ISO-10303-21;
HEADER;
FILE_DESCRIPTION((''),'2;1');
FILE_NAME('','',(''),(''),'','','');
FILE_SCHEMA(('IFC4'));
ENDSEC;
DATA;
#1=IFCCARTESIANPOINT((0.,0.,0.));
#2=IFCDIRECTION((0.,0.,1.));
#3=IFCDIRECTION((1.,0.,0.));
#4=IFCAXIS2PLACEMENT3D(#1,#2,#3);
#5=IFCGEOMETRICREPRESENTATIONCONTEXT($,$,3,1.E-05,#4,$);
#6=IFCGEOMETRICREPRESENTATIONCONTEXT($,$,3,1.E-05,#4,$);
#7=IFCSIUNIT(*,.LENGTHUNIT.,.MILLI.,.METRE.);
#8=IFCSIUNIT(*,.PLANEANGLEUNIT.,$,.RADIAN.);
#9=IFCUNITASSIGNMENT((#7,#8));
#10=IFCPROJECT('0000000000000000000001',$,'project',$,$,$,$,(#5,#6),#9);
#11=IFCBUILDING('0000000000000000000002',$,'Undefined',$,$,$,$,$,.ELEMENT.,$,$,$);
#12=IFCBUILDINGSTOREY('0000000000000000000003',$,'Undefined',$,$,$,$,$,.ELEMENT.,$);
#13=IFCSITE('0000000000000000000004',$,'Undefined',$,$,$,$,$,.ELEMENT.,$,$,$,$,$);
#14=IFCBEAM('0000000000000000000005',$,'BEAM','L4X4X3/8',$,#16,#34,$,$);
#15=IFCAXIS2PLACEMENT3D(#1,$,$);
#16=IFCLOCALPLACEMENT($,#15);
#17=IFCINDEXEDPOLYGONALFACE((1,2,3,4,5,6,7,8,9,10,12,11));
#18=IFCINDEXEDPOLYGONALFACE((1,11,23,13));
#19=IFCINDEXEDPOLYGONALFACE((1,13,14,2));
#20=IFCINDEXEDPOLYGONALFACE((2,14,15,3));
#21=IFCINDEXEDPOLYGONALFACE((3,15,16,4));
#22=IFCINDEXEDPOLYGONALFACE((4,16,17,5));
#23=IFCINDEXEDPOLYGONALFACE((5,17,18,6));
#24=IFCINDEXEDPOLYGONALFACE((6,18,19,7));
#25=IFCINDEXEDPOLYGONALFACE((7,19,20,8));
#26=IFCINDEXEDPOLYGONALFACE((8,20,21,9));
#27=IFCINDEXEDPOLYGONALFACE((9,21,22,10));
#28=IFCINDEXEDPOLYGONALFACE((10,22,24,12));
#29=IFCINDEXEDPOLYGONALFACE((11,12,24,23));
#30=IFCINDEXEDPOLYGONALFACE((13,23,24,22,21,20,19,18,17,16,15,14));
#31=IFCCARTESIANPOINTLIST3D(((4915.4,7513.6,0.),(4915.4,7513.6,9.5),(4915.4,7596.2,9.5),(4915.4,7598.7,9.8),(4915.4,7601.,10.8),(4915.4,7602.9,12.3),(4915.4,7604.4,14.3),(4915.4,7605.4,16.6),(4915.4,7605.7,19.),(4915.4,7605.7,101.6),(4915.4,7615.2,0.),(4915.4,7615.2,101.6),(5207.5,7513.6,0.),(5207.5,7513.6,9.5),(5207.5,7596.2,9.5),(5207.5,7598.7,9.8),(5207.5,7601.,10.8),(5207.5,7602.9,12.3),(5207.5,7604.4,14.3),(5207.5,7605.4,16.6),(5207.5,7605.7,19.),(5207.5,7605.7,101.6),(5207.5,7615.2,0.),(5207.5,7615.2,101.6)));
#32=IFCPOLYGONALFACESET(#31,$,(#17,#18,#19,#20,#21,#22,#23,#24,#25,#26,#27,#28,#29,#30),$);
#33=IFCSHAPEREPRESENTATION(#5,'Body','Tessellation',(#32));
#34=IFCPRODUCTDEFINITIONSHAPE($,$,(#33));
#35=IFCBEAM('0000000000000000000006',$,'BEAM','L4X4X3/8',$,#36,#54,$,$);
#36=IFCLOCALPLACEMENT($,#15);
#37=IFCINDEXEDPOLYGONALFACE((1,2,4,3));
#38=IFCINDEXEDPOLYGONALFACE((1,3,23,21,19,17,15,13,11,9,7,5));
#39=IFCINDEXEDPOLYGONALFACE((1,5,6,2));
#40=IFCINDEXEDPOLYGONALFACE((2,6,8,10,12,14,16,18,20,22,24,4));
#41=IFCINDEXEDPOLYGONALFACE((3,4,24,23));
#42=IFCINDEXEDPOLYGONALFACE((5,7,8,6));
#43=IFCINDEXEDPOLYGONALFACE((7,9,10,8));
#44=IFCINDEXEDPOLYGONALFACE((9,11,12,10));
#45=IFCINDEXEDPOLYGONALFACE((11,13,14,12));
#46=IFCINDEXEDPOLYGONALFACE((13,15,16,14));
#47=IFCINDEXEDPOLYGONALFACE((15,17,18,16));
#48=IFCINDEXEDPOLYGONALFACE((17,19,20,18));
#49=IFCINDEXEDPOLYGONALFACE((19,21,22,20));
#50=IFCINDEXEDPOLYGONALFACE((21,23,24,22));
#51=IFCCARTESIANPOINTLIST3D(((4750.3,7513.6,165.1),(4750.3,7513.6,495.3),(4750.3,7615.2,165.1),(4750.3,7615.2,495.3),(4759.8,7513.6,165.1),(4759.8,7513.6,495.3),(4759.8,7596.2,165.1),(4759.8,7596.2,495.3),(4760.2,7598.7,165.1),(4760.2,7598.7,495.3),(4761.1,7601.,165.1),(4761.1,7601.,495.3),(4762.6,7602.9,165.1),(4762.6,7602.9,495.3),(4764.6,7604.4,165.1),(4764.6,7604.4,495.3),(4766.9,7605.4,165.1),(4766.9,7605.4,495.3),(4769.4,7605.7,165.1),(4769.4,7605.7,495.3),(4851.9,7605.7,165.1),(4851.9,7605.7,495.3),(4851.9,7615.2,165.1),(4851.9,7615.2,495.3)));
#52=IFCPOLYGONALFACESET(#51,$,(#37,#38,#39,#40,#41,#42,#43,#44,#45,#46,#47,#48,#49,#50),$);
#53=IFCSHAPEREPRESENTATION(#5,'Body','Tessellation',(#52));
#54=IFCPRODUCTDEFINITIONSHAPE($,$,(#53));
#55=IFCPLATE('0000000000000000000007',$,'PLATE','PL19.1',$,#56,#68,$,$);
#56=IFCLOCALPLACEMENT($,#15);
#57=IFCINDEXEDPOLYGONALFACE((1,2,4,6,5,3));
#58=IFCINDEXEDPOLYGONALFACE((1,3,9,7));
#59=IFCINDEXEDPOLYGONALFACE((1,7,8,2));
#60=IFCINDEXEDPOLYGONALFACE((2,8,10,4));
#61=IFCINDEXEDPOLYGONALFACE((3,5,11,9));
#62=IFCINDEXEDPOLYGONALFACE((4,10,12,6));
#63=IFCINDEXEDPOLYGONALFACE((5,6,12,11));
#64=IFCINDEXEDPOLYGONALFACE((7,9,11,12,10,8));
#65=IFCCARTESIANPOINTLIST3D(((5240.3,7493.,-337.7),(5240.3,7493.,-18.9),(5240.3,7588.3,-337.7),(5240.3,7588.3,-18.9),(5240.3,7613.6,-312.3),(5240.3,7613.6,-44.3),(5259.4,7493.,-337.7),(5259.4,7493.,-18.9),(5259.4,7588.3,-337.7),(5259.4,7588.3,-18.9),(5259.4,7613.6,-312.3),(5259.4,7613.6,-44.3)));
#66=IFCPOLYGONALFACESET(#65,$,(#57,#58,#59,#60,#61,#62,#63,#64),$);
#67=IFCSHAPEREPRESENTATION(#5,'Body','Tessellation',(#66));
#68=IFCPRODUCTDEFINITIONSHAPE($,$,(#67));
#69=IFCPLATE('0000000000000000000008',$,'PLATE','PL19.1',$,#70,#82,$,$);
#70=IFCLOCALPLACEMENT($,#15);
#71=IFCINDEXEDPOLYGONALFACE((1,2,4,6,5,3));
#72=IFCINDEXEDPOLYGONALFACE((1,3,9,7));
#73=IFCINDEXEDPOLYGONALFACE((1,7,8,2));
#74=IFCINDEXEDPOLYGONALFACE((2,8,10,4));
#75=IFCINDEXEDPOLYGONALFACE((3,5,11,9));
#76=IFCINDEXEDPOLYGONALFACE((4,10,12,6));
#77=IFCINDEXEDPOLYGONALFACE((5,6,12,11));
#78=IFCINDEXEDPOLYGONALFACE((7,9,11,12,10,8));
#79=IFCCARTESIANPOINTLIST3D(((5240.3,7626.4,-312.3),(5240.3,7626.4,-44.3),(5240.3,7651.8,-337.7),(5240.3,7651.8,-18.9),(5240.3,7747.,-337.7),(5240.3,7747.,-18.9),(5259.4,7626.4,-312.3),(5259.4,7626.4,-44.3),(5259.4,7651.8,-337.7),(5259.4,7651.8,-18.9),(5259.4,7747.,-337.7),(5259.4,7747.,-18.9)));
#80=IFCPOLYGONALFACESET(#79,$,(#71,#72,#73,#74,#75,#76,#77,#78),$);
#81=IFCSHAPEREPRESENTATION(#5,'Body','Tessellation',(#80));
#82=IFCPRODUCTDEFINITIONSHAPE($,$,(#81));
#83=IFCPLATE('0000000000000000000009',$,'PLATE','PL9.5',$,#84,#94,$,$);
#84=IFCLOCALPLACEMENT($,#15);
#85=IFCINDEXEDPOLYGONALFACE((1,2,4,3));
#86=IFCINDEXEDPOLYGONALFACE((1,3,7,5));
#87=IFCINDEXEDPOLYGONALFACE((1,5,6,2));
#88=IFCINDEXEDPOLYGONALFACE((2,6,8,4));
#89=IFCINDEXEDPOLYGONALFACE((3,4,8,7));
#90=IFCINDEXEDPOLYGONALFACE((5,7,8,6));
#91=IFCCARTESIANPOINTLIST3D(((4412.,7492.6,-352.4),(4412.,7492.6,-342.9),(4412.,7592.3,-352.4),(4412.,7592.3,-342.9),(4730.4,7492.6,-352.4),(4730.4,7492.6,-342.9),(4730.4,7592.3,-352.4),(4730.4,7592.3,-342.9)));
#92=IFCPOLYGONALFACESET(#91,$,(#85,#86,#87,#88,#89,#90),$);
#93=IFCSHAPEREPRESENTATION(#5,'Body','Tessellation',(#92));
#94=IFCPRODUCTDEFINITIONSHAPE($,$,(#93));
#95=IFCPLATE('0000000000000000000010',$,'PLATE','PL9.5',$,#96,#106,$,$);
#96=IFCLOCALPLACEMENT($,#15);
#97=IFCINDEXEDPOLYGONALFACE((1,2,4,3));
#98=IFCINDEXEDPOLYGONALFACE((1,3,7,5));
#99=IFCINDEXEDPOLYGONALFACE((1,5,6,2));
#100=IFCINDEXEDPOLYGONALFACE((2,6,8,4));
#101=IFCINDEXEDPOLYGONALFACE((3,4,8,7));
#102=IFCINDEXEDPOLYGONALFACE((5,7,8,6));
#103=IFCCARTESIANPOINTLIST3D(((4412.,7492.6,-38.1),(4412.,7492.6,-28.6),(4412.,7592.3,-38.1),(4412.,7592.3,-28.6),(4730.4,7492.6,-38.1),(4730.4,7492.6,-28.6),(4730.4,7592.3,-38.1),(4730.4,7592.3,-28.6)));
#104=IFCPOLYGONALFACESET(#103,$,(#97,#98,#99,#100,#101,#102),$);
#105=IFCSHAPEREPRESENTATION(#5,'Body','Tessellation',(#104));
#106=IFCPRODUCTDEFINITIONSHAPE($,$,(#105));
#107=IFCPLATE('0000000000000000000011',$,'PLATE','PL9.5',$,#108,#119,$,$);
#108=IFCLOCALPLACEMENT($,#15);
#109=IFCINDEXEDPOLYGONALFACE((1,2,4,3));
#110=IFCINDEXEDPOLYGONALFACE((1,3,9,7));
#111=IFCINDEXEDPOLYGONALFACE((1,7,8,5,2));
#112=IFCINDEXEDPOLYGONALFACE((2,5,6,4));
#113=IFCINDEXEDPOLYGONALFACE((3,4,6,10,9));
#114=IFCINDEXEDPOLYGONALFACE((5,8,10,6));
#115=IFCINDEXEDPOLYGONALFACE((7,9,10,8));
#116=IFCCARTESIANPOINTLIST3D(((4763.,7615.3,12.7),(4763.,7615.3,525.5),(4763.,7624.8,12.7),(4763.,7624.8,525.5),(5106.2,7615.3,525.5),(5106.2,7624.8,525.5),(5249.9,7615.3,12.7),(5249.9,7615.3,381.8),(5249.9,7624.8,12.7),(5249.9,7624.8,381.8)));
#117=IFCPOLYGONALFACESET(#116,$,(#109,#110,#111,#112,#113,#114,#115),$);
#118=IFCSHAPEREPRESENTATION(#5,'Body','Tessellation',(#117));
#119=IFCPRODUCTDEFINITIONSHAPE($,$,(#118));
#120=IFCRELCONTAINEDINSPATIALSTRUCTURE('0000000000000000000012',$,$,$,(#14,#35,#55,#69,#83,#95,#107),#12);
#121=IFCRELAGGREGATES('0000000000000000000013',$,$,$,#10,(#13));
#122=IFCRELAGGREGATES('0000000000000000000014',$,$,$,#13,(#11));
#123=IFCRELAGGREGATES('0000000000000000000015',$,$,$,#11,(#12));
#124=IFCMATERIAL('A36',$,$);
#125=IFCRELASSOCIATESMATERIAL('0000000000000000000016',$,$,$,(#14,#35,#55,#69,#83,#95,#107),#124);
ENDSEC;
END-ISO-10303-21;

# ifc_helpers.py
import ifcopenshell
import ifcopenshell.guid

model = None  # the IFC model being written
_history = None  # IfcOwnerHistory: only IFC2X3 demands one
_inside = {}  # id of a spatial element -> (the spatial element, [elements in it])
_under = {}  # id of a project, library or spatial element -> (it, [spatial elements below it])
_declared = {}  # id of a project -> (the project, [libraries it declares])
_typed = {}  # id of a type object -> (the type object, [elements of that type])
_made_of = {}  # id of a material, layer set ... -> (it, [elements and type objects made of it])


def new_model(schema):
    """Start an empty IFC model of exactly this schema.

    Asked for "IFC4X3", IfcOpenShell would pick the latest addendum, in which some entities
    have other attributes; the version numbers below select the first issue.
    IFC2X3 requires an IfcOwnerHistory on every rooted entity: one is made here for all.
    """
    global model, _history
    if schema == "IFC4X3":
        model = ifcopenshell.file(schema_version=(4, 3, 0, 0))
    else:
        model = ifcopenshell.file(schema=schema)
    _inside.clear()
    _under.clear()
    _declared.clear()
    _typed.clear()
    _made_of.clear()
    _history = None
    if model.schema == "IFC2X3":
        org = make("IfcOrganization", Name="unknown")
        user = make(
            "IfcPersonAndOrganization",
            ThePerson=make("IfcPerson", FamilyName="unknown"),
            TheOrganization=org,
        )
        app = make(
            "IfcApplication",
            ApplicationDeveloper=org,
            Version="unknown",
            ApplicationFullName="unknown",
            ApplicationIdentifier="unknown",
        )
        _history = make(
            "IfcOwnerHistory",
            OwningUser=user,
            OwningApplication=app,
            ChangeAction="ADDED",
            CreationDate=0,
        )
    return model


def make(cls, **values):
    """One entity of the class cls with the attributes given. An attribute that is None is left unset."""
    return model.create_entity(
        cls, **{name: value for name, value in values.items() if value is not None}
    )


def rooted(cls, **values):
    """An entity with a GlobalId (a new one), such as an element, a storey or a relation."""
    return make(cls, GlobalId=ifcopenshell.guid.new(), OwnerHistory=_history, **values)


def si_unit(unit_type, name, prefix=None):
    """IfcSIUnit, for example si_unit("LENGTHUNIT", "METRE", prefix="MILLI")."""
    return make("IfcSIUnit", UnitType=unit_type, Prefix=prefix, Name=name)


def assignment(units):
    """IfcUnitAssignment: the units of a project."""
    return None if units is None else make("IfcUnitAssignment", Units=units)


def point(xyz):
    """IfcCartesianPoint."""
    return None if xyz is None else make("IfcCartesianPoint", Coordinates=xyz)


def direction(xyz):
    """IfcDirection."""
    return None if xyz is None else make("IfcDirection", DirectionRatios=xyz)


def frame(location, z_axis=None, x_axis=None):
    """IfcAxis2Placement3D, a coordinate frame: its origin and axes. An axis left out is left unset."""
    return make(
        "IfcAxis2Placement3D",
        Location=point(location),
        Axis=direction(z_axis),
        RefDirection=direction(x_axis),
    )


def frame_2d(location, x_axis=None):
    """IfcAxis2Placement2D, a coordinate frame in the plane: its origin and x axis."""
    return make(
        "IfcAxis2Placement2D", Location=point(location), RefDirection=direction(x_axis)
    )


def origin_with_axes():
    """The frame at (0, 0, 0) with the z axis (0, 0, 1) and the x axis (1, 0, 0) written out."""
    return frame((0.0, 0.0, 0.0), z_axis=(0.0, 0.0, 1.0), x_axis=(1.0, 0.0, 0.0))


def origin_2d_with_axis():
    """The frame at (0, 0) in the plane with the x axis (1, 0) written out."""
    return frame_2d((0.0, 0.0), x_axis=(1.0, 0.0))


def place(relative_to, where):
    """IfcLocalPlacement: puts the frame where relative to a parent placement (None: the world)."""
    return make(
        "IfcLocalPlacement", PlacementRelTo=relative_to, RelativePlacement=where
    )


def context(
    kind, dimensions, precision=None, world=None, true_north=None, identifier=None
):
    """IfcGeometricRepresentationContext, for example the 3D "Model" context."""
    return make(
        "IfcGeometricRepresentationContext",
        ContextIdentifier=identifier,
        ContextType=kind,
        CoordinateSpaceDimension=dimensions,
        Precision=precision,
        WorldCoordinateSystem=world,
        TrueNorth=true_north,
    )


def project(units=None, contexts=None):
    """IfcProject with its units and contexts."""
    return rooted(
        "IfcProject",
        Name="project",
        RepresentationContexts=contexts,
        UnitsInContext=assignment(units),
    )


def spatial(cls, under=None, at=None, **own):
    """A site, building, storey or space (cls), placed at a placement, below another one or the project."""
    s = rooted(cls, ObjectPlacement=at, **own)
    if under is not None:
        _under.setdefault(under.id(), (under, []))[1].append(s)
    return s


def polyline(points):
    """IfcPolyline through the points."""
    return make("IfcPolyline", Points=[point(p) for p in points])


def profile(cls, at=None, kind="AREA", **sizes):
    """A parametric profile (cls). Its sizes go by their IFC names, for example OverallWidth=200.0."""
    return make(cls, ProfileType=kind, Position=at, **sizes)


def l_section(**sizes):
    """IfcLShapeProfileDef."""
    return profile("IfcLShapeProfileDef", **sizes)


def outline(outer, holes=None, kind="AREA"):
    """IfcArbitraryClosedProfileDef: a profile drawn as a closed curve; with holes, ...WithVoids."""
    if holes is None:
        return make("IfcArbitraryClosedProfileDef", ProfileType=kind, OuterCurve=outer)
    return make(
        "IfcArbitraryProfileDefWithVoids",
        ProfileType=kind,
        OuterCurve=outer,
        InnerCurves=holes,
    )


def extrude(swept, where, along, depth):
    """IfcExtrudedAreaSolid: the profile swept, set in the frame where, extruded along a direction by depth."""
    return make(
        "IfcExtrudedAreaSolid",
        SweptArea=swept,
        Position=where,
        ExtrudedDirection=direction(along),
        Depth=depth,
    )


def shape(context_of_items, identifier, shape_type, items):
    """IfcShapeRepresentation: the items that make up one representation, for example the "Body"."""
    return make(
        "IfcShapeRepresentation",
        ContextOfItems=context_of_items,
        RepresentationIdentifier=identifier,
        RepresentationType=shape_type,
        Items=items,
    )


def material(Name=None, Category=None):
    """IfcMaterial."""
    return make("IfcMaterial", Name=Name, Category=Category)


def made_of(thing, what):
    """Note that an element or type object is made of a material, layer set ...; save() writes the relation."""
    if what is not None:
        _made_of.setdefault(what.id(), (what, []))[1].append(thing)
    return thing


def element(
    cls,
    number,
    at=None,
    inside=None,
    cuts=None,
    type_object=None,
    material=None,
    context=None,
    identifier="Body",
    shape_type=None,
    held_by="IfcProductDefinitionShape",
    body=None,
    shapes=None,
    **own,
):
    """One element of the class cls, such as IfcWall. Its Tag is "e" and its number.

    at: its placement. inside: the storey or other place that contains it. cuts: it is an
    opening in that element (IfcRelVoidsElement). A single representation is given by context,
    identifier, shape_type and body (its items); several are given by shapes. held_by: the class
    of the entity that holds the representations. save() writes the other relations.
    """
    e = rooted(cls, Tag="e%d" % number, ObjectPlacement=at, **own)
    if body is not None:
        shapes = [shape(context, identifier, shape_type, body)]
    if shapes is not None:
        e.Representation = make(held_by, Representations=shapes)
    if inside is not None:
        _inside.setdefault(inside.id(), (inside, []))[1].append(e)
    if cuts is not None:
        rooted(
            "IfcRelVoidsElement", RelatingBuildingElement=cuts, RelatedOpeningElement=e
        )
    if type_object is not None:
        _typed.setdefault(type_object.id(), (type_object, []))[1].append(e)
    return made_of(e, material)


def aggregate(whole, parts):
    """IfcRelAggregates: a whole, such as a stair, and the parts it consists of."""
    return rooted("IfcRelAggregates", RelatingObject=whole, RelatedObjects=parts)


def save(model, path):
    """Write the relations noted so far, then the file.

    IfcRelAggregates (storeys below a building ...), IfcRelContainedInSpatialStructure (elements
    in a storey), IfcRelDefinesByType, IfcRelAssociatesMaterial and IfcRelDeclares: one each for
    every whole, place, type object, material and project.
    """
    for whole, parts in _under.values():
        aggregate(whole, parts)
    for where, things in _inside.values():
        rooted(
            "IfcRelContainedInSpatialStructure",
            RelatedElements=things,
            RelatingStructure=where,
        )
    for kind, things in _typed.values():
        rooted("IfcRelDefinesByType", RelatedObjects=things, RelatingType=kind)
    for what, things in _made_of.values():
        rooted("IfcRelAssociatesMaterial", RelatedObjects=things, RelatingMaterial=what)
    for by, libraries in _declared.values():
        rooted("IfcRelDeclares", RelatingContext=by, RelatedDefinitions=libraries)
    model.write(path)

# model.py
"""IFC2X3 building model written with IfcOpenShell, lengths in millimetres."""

from ifc_helpers import new_model, si_unit, frame, origin_with_axes, origin_2d_with_axis, place, context, project, spatial, polyline, l_section, outline, extrude, material, element, save


model = new_model("IFC2X3")

# Units and contexts
context_of_model_1 = context(None, 3, precision=1e-05, world=origin_with_axes())
context_of_model_2 = context(None, 3, precision=1e-05, world=origin_with_axes())
ifc_project = project(units=[si_unit("LENGTHUNIT", "METRE", prefix="MILLI"), si_unit("PLANEANGLEUNIT", "RADIAN")], contexts=[context_of_model_1, context_of_model_2])

# Site, building, storey
site = spatial("IfcSite", under=ifc_project, Name="Undefined", CompositionType="ELEMENT")
building = spatial("IfcBuilding", under=site, Name="Undefined", CompositionType="ELEMENT")
storey = spatial("IfcBuildingStorey", under=building, Name="Undefined", CompositionType="ELEMENT")

# Shared definitions
ifc_material_1 = material(Name="A36")

# Beams
beam_1_placement = place(None, frame((4915.4, 7564.4, 50.8), z_axis=(0.0, -1.0, 0.0), x_axis=(1.0, 0.0, 0.0)))
element("IfcBeam", 1, at=beam_1_placement, inside=storey, material=ifc_material_1, Name="BEAM", Description="L4X4X3/8", context=context_of_model_1, shape_type="SweptSolid", body=[
    extrude(l_section(Depth=101.6, Width=101.6, Thickness=9.5, FilletRadius=9.5, at=origin_2d_with_axis()), frame((0.0, 0.0, 0.0), z_axis=(-1.0, 0.0, 0.0), x_axis=(0.0, 0.0, 1.0)), (0.0, 0.0, -1.0), 292.1),
])
beam_2_placement = place(None, frame((4801.1, 7564.4, 495.3), z_axis=(0.0, -1.0, 0.0), x_axis=(0.0, 0.0, -1.0)))
element("IfcBeam", 2, at=beam_2_placement, inside=storey, material=ifc_material_1, Name="BEAM", Description="L4X4X3/8", context=context_of_model_1, shape_type="SweptSolid", body=[
    extrude(l_section(Depth=101.6, Width=101.6, Thickness=9.5, FilletRadius=9.5, at=origin_2d_with_axis()), frame((0.0, 0.0, 0.0), z_axis=(-1.0, 0.0, 0.0), x_axis=(0.0, 0.0, 1.0)), (0.0, 0.0, -1.0), 330.2),
])

# Plates
plate_1_placement = place(None, frame((5240.3, 7493.0, -337.7), z_axis=(1.0, 0.0, 0.0), x_axis=(0.0, 1.0, 0.0)))
element("IfcPlate", 3, at=plate_1_placement, inside=storey, material=ifc_material_1, Name="PLATE", Description="PL19.1", context=context_of_model_1, shape_type="SweptSolid", body=[
    extrude(outline(polyline([(0.0, 318.8), (95.3, 318.8), (120.7, 293.4), (120.7, 25.4), (95.3, 0.0), (0.0, 0.0), (0.0, 318.8)])), origin_with_axes(), (0.0, 0.0, 1.0), 19.1),
])
plate_2_placement = place(None, frame((5240.3, 7626.4, -337.7), z_axis=(1.0, 0.0, 0.0), x_axis=(0.0, 1.0, 0.0)))
element("IfcPlate", 4, at=plate_2_placement, inside=storey, material=ifc_material_1, Name="PLATE", Description="PL19.1", context=context_of_model_1, shape_type="SweptSolid", body=[
    extrude(outline(polyline([(0.0, 293.4), (25.4, 318.8), (120.7, 318.8), (120.7, 0.0), (25.4, 0.0), (0.0, 25.4), (0.0, 293.4)])), origin_with_axes(), (0.0, 0.0, 1.0), 19.1),
])
for number, where, z_axis, x_axis, name in (
    (5, (4412.0, 7492.6, -342.9), (0.0, 0.0, -1.0), (0.0, 1.0, 0.0), "PLATE"),
    (6, (4412.0, 7492.6, -28.6), (0.0, 0.0, -1.0), (0.0, 1.0, 0.0), "PLATE"),
):
    element("IfcPlate", number, at=place(None, frame(where, z_axis=z_axis, x_axis=x_axis)), inside=storey, material=ifc_material_1, Name=name, Description="PL9.5", context=context_of_model_1, shape_type="SweptSolid", body=[
        extrude(outline(polyline([(0.0, 0.0), (0.0, 318.5), (99.7, 318.5), (99.7, 0.0), (0.0, 0.0)])), origin_with_axes(), (0.0, 0.0, 1.0), 9.5),
    ])
plate_3_placement = place(None, frame((4763.0, 7615.3, 12.7), z_axis=(0.0, 1.0, 0.0), x_axis=(0.0, 0.0, 1.0)))
element("IfcPlate", 7, at=plate_3_placement, inside=storey, material=ifc_material_1, Name="PLATE", Description="PL9.5", context=context_of_model_1, shape_type="SweptSolid", body=[
    extrude(outline(polyline([(0.0, 0.0), (0.0, 486.8), (369.1, 486.8), (512.8, 343.2), (512.8, 0.0), (0.0, 0.0)])), origin_with_axes(), (0.0, 0.0, 1.0), 9.5),
])

save(model, "model.ifc")
